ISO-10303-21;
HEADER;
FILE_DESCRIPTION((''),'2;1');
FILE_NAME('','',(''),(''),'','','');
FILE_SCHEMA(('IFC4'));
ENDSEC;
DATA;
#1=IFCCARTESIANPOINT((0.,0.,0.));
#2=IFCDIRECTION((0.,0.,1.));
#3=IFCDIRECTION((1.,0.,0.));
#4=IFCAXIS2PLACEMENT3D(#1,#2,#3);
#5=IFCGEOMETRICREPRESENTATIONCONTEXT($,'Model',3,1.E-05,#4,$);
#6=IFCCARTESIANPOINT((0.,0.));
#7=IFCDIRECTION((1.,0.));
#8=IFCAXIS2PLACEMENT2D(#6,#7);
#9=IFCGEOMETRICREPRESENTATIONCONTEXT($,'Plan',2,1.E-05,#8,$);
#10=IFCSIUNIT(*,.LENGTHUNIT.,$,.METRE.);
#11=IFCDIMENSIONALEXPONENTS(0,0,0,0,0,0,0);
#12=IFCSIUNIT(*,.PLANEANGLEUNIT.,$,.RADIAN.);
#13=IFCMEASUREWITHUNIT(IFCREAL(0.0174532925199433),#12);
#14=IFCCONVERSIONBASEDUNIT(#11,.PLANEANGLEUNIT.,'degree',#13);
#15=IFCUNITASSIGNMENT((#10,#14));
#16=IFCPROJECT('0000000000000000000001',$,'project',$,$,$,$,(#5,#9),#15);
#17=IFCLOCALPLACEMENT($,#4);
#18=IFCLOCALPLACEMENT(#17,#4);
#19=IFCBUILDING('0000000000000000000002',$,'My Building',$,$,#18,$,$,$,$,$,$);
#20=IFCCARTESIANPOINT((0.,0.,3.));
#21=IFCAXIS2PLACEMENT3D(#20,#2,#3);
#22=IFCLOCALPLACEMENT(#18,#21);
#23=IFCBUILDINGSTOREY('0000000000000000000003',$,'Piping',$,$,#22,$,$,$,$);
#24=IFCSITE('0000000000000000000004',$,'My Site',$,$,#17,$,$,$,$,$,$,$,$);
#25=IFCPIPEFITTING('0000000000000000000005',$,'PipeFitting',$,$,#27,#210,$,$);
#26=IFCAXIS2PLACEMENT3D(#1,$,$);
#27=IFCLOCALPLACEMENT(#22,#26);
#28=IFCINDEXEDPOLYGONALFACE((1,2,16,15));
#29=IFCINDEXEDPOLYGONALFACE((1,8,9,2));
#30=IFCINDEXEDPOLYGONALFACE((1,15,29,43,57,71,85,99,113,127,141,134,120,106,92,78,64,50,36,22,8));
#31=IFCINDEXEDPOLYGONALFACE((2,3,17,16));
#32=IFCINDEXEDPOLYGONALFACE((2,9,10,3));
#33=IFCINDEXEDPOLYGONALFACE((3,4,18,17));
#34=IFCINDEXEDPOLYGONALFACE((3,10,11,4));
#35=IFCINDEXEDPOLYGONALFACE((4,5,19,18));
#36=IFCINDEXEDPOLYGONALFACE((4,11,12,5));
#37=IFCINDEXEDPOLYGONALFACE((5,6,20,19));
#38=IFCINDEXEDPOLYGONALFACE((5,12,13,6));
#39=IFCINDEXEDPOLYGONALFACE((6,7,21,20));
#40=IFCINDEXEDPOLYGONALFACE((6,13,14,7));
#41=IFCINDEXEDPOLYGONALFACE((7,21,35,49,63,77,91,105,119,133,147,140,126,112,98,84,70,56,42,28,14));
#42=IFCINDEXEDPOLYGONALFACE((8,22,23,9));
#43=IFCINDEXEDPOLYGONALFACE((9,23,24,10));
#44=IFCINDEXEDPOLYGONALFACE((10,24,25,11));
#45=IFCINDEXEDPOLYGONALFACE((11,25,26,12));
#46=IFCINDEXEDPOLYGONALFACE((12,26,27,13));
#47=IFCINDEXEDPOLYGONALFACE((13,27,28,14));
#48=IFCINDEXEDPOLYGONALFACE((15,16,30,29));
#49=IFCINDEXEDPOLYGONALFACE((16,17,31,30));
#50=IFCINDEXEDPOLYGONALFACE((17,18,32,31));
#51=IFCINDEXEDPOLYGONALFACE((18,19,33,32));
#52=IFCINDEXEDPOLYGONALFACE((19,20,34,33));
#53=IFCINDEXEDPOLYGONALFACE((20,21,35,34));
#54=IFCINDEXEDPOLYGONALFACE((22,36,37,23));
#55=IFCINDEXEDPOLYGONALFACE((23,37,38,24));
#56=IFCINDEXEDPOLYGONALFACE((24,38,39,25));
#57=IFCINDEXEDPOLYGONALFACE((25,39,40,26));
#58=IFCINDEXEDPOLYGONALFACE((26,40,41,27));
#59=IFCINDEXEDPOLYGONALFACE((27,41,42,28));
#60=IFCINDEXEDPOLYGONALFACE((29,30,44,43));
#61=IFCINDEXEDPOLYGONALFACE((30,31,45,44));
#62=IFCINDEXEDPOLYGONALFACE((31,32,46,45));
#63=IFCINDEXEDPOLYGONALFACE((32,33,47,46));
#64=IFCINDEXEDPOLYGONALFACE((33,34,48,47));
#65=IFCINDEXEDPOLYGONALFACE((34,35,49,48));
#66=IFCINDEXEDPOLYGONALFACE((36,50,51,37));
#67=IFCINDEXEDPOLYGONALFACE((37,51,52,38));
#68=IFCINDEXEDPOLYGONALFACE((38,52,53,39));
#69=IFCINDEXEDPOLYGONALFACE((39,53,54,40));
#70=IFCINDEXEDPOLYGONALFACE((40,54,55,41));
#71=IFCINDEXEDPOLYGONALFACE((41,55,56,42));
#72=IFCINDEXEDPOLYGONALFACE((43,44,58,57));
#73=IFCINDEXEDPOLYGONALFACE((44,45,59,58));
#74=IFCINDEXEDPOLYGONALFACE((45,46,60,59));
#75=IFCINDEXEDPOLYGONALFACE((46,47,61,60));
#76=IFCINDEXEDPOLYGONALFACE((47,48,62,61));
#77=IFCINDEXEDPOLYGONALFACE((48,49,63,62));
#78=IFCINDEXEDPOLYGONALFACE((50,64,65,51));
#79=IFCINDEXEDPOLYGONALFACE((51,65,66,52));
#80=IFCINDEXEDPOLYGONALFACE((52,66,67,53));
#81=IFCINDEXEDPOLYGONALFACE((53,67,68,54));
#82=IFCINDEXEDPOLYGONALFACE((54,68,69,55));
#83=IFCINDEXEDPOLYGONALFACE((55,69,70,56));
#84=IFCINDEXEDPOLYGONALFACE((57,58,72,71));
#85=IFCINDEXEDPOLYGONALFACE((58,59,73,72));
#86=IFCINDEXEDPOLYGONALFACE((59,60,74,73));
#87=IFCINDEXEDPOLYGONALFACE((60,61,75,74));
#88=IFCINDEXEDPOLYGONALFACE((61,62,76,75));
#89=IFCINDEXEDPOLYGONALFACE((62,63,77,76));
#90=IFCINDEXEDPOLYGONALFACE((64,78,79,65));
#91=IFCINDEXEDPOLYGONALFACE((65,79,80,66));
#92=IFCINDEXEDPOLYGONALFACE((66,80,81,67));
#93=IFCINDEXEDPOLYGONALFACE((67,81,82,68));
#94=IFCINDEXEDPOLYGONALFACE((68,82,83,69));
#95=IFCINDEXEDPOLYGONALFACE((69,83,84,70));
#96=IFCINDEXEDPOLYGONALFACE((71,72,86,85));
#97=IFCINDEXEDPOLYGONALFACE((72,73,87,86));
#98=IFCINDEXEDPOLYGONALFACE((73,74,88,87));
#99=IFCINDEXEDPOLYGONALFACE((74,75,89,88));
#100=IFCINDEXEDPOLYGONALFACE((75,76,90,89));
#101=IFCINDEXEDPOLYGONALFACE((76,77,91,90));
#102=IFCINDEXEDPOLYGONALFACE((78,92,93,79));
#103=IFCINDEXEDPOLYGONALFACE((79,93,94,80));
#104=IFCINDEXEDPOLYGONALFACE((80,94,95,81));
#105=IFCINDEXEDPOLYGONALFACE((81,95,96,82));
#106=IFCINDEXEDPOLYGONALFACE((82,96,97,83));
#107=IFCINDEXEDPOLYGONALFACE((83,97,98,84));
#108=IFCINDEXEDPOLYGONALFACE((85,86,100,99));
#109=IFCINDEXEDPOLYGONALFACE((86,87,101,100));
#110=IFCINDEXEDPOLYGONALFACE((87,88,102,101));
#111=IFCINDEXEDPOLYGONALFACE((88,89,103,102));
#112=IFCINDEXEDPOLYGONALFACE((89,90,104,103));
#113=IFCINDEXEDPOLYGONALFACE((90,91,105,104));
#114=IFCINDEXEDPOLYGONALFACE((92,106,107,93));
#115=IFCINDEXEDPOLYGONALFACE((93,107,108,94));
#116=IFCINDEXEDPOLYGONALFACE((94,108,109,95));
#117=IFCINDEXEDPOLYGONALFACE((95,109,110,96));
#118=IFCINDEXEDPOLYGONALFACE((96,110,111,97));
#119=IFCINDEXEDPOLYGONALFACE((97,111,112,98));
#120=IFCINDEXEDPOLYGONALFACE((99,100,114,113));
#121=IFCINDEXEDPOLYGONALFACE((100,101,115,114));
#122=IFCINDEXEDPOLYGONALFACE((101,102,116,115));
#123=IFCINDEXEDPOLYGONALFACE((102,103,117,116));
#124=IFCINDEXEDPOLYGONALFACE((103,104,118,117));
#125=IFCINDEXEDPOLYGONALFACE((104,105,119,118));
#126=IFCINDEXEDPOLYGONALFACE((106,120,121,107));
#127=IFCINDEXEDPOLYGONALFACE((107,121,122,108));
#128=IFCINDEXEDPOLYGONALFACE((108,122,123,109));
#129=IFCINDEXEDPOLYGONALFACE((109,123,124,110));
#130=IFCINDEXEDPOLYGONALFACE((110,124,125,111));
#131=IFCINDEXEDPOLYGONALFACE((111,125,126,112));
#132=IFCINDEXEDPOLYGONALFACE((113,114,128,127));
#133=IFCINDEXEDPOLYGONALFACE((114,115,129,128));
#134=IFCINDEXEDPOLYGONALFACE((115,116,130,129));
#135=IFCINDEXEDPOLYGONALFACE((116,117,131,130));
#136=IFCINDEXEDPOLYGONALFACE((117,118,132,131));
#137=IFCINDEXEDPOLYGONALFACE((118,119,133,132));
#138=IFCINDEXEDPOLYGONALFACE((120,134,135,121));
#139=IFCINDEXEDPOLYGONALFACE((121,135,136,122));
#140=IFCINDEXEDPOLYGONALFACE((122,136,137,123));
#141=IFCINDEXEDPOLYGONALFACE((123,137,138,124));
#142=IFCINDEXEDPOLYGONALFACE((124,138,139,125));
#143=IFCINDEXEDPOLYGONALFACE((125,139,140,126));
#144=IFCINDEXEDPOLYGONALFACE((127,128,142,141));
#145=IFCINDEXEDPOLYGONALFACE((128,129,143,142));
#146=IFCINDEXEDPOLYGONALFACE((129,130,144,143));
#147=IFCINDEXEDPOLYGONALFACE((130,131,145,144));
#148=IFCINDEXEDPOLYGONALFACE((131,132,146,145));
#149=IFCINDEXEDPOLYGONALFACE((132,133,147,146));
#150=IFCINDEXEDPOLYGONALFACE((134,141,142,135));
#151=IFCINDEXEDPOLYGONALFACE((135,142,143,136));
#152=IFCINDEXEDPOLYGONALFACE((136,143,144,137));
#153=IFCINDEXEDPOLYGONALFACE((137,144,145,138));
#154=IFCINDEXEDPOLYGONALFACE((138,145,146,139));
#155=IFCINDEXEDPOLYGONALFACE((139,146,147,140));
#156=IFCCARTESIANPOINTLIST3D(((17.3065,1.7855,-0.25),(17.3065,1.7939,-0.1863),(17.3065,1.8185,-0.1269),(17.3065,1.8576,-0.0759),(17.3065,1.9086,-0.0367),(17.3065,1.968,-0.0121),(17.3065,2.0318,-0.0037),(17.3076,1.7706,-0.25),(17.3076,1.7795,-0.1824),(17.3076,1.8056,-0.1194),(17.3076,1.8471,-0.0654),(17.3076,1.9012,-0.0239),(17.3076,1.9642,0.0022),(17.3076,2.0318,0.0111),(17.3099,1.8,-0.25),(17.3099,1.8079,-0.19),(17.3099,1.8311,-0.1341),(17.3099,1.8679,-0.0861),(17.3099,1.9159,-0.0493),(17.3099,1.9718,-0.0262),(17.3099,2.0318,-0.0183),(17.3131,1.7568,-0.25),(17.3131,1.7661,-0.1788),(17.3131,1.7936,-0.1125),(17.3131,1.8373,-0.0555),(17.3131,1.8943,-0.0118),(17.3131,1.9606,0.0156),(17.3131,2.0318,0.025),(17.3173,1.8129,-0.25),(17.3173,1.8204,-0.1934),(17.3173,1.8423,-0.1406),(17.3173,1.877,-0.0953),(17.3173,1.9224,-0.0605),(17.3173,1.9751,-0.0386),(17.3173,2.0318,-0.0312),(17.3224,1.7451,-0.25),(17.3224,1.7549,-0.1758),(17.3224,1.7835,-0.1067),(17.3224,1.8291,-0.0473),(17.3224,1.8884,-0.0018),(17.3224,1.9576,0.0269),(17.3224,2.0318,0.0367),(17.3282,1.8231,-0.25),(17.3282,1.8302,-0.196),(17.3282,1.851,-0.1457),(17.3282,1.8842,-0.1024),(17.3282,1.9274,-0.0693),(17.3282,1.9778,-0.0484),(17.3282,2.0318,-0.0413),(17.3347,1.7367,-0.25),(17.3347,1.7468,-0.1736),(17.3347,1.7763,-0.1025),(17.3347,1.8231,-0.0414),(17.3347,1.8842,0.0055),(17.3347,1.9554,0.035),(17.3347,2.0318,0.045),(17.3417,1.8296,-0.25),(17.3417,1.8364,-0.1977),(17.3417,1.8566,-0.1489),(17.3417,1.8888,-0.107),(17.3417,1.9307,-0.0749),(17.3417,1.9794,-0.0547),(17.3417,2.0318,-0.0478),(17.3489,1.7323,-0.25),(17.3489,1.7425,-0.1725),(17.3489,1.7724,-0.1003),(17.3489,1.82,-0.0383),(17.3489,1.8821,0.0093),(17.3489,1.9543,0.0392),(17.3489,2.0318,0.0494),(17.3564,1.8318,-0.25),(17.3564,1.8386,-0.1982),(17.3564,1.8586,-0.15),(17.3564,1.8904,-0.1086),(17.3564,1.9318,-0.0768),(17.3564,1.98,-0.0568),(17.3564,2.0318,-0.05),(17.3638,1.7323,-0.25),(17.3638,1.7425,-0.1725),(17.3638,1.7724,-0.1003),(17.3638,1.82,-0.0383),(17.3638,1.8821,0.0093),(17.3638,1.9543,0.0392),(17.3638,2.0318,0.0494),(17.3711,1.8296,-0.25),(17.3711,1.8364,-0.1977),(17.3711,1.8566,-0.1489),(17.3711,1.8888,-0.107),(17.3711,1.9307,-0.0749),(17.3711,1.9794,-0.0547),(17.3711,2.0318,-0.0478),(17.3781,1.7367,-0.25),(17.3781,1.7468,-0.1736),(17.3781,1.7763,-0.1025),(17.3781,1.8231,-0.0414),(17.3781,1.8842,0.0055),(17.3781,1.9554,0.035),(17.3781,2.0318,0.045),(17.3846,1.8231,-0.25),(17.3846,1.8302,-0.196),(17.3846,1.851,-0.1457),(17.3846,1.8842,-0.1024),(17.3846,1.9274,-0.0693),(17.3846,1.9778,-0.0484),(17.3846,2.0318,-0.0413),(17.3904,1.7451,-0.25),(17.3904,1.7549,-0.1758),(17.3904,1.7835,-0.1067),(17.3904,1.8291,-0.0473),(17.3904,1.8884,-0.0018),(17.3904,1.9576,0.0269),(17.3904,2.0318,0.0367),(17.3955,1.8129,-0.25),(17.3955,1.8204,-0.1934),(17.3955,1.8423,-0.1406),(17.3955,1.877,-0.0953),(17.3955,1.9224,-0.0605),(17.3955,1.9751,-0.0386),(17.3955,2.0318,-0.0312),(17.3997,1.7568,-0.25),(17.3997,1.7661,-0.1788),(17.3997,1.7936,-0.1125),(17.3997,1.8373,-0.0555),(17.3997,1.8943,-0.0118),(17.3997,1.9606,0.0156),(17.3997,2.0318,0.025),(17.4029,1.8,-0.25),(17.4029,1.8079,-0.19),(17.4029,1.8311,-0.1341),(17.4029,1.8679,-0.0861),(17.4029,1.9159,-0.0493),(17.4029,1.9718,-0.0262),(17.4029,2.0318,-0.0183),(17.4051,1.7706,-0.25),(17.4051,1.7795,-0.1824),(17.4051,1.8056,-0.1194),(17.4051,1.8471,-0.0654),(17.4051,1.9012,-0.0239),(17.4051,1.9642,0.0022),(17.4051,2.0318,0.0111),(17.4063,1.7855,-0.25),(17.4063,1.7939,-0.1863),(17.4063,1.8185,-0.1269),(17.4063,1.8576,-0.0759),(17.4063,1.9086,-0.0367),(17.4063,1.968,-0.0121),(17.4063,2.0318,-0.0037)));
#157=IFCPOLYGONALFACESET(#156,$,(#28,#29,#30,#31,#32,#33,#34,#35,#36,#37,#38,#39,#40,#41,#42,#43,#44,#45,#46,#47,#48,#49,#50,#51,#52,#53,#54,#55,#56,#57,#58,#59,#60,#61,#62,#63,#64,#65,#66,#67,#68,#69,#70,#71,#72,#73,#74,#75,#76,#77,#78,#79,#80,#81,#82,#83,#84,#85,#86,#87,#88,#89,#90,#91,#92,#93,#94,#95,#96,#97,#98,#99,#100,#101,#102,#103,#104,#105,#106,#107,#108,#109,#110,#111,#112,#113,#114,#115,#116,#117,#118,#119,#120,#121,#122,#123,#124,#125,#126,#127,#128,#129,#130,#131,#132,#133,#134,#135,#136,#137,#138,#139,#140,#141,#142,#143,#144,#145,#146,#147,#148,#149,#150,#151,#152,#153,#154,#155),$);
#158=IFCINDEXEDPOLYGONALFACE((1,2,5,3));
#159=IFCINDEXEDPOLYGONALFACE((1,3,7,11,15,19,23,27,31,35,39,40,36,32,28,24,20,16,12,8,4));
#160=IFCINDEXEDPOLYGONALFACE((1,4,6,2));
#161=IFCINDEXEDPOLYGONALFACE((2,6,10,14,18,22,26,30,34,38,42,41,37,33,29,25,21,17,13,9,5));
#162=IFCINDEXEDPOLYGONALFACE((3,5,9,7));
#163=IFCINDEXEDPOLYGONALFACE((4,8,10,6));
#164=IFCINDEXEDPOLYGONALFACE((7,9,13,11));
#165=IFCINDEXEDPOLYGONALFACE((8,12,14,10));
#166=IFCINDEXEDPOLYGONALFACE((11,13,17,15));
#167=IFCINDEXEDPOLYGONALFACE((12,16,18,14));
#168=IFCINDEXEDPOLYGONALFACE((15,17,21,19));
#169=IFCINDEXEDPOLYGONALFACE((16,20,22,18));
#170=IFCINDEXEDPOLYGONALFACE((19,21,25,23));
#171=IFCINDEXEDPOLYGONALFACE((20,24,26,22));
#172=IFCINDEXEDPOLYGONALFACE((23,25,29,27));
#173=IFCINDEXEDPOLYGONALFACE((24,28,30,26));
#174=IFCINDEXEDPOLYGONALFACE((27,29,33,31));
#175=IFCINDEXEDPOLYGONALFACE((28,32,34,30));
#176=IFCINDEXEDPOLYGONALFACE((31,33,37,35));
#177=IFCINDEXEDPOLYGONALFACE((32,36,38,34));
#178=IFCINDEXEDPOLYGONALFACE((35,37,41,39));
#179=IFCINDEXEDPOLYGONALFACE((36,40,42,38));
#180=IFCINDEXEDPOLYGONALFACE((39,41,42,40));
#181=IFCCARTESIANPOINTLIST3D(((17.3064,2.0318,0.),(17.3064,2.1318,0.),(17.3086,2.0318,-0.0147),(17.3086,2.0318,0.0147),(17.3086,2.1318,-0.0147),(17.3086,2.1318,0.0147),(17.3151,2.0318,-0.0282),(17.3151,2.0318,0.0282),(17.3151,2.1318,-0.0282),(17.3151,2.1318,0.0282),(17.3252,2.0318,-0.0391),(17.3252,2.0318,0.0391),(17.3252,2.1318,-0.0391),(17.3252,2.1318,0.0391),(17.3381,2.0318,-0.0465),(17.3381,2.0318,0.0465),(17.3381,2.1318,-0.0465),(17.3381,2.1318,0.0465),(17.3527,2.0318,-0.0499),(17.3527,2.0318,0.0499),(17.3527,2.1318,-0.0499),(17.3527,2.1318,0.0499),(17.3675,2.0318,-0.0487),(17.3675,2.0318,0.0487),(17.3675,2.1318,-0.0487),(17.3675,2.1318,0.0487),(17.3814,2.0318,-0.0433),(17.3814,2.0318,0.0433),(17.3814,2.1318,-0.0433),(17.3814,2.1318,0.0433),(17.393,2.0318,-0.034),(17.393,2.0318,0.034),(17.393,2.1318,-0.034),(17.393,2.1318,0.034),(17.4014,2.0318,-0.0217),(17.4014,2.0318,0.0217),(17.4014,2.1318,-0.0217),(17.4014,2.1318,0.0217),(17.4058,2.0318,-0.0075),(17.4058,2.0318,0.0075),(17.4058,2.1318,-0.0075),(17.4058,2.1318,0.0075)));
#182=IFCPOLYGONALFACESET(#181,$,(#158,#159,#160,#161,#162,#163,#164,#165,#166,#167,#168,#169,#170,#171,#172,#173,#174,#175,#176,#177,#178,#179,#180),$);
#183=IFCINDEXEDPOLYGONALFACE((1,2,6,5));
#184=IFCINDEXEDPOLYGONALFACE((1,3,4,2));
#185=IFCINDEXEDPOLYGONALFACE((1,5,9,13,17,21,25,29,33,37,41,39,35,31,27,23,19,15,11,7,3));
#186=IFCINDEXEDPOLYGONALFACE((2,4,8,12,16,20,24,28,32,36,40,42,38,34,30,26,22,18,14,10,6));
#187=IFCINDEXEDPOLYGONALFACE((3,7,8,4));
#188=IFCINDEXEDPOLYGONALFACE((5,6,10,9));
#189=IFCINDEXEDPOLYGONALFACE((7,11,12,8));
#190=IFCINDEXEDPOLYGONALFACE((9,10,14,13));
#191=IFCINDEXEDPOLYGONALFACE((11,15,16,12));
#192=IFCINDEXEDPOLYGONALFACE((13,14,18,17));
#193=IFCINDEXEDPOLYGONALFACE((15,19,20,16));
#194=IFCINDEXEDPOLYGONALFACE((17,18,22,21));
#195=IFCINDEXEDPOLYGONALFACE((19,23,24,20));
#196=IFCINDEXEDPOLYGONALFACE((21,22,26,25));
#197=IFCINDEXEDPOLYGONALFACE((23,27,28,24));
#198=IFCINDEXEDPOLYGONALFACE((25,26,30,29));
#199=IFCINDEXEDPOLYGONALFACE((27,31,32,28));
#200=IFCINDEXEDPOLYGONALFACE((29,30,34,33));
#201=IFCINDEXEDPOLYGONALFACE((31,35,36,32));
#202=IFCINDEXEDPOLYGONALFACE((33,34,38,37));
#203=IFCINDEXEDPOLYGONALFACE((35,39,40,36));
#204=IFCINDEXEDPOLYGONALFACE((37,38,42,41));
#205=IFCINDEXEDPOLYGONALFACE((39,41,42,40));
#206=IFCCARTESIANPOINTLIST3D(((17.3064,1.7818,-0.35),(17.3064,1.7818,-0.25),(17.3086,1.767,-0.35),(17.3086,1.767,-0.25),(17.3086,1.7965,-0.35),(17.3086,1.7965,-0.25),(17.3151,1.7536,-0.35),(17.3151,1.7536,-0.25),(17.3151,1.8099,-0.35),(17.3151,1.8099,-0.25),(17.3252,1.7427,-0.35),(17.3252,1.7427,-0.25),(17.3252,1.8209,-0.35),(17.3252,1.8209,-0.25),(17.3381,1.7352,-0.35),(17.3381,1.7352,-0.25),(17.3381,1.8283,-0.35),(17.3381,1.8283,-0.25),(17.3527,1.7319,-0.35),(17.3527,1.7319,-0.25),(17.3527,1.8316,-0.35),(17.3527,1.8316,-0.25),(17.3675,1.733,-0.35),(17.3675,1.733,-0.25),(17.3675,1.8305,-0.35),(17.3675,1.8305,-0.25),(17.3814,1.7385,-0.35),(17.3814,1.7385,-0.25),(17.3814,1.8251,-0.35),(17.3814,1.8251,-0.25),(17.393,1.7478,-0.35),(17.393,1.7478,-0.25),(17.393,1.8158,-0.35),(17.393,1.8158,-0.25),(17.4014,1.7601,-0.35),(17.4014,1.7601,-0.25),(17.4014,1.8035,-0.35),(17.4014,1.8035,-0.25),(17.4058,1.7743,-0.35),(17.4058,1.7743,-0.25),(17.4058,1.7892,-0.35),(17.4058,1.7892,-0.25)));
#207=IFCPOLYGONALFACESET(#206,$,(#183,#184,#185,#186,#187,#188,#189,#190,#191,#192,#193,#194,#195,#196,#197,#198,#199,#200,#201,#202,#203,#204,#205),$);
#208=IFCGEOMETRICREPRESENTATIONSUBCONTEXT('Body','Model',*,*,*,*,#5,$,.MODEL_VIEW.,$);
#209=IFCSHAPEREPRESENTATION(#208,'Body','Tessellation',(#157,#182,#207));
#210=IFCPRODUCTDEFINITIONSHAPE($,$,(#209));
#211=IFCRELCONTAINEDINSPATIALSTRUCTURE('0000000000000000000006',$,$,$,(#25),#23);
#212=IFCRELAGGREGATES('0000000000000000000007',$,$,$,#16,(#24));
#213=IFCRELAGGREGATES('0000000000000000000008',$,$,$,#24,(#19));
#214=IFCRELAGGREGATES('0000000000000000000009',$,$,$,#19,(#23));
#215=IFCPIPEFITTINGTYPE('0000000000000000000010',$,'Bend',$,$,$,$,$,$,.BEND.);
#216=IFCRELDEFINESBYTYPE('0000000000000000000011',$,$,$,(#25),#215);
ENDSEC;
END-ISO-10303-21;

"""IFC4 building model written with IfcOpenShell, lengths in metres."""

from ifc_helpers import new_model, entity, si_unit, converted_unit, frame, origin_with_axes, origin_2d_with_axis, place, context, subcontext, project, spatial, circle, extrude, source, transform, mapped, type_object, type_shapes, element, save


model = new_model("IFC4")

# Units and contexts
model_context = context("Model", 3, precision=1e-05, world=origin_with_axes())
plan_context = context("Plan", 2, precision=1e-05, world=origin_2d_with_axis())
body_context = subcontext(model_context, "Body", "Model", "MODEL_VIEW")
ifc_project = project(units=[si_unit("LENGTHUNIT", "METRE"), converted_unit("PLANEANGLEUNIT", "degree", entity("IfcReal", 0.0174532925199433), si_unit("PLANEANGLEUNIT", "RADIAN"), dimensions=[0, 0, 0, 0, 0, 0, 0])], contexts=[model_context, plan_context])

# Site, building, storey
site_placement = place(None, origin_with_axes())
site = spatial("IfcSite", under=ifc_project, at=site_placement, Name="My Site")
building_placement = place(site_placement, origin_with_axes())
building = spatial("IfcBuilding", under=site, at=building_placement, Name="My Building")
storey_placement = place(building_placement, frame((0.0, 0.0, 3.0), z_axis=(0.0, 0.0, 1.0), x_axis=(1.0, 0.0, 0.0)))
storey = spatial("IfcBuildingStorey", under=building, at=storey_placement, Name="Piping")

# Pipe fitting
pipe_fitting_type = type_object("IfcPipeFittingType", Name="Bend", PredefinedType="BEND")
shared_shape = source(origin_with_axes(), body_context, "Body", "SolidModel", [
    entity("IfcSweptDiskSolid", entity("IfcIndexedPolyCurve", entity("IfcCartesianPointList3D", [[0.0, 0.0, -0.1], [0.0, -0.0732, -0.2768], [0.0, -0.25, -0.35]]), [entity("IfcArcIndex", [1, 2, 3])]), 0.05),
    extrude(circle(Radius=0.05), origin_with_axes(), (0.0, 0.0, -1.0), 0.1),
    extrude(circle(Radius=0.05), frame((0.0, -0.25, -0.35), z_axis=(0.0, -1.0, 0.0), x_axis=(1.0, 0.0, 0.0)), (0.0, 0.0, 1.0), 0.1),
])
type_shapes(pipe_fitting_type, [shared_shape])
for number, where, z_axis, x_axis, name in (
    (1, (17.3564, 2.1318, 0.0), (0.0, 1.0, 0.0), (-1.0, 0.0, 0.0), "PipeFitting"),
):
    element("IfcPipeFitting", number, at=place(storey_placement, frame(where, z_axis=z_axis, x_axis=x_axis)), inside=storey, type_object=pipe_fitting_type, Name=name, context=body_context, shape_type="MappedRepresentation", body=[
        mapped(shared_shape, transform((0.0, 0.0, 0.0), x_axis=(1.0, 0.0, 0.0), y_axis=(0.0, 1.0, 0.0), z_axis=(0.0, 0.0, 1.0), scale=1.0)),
    ])

save(model, "model.ifc")
